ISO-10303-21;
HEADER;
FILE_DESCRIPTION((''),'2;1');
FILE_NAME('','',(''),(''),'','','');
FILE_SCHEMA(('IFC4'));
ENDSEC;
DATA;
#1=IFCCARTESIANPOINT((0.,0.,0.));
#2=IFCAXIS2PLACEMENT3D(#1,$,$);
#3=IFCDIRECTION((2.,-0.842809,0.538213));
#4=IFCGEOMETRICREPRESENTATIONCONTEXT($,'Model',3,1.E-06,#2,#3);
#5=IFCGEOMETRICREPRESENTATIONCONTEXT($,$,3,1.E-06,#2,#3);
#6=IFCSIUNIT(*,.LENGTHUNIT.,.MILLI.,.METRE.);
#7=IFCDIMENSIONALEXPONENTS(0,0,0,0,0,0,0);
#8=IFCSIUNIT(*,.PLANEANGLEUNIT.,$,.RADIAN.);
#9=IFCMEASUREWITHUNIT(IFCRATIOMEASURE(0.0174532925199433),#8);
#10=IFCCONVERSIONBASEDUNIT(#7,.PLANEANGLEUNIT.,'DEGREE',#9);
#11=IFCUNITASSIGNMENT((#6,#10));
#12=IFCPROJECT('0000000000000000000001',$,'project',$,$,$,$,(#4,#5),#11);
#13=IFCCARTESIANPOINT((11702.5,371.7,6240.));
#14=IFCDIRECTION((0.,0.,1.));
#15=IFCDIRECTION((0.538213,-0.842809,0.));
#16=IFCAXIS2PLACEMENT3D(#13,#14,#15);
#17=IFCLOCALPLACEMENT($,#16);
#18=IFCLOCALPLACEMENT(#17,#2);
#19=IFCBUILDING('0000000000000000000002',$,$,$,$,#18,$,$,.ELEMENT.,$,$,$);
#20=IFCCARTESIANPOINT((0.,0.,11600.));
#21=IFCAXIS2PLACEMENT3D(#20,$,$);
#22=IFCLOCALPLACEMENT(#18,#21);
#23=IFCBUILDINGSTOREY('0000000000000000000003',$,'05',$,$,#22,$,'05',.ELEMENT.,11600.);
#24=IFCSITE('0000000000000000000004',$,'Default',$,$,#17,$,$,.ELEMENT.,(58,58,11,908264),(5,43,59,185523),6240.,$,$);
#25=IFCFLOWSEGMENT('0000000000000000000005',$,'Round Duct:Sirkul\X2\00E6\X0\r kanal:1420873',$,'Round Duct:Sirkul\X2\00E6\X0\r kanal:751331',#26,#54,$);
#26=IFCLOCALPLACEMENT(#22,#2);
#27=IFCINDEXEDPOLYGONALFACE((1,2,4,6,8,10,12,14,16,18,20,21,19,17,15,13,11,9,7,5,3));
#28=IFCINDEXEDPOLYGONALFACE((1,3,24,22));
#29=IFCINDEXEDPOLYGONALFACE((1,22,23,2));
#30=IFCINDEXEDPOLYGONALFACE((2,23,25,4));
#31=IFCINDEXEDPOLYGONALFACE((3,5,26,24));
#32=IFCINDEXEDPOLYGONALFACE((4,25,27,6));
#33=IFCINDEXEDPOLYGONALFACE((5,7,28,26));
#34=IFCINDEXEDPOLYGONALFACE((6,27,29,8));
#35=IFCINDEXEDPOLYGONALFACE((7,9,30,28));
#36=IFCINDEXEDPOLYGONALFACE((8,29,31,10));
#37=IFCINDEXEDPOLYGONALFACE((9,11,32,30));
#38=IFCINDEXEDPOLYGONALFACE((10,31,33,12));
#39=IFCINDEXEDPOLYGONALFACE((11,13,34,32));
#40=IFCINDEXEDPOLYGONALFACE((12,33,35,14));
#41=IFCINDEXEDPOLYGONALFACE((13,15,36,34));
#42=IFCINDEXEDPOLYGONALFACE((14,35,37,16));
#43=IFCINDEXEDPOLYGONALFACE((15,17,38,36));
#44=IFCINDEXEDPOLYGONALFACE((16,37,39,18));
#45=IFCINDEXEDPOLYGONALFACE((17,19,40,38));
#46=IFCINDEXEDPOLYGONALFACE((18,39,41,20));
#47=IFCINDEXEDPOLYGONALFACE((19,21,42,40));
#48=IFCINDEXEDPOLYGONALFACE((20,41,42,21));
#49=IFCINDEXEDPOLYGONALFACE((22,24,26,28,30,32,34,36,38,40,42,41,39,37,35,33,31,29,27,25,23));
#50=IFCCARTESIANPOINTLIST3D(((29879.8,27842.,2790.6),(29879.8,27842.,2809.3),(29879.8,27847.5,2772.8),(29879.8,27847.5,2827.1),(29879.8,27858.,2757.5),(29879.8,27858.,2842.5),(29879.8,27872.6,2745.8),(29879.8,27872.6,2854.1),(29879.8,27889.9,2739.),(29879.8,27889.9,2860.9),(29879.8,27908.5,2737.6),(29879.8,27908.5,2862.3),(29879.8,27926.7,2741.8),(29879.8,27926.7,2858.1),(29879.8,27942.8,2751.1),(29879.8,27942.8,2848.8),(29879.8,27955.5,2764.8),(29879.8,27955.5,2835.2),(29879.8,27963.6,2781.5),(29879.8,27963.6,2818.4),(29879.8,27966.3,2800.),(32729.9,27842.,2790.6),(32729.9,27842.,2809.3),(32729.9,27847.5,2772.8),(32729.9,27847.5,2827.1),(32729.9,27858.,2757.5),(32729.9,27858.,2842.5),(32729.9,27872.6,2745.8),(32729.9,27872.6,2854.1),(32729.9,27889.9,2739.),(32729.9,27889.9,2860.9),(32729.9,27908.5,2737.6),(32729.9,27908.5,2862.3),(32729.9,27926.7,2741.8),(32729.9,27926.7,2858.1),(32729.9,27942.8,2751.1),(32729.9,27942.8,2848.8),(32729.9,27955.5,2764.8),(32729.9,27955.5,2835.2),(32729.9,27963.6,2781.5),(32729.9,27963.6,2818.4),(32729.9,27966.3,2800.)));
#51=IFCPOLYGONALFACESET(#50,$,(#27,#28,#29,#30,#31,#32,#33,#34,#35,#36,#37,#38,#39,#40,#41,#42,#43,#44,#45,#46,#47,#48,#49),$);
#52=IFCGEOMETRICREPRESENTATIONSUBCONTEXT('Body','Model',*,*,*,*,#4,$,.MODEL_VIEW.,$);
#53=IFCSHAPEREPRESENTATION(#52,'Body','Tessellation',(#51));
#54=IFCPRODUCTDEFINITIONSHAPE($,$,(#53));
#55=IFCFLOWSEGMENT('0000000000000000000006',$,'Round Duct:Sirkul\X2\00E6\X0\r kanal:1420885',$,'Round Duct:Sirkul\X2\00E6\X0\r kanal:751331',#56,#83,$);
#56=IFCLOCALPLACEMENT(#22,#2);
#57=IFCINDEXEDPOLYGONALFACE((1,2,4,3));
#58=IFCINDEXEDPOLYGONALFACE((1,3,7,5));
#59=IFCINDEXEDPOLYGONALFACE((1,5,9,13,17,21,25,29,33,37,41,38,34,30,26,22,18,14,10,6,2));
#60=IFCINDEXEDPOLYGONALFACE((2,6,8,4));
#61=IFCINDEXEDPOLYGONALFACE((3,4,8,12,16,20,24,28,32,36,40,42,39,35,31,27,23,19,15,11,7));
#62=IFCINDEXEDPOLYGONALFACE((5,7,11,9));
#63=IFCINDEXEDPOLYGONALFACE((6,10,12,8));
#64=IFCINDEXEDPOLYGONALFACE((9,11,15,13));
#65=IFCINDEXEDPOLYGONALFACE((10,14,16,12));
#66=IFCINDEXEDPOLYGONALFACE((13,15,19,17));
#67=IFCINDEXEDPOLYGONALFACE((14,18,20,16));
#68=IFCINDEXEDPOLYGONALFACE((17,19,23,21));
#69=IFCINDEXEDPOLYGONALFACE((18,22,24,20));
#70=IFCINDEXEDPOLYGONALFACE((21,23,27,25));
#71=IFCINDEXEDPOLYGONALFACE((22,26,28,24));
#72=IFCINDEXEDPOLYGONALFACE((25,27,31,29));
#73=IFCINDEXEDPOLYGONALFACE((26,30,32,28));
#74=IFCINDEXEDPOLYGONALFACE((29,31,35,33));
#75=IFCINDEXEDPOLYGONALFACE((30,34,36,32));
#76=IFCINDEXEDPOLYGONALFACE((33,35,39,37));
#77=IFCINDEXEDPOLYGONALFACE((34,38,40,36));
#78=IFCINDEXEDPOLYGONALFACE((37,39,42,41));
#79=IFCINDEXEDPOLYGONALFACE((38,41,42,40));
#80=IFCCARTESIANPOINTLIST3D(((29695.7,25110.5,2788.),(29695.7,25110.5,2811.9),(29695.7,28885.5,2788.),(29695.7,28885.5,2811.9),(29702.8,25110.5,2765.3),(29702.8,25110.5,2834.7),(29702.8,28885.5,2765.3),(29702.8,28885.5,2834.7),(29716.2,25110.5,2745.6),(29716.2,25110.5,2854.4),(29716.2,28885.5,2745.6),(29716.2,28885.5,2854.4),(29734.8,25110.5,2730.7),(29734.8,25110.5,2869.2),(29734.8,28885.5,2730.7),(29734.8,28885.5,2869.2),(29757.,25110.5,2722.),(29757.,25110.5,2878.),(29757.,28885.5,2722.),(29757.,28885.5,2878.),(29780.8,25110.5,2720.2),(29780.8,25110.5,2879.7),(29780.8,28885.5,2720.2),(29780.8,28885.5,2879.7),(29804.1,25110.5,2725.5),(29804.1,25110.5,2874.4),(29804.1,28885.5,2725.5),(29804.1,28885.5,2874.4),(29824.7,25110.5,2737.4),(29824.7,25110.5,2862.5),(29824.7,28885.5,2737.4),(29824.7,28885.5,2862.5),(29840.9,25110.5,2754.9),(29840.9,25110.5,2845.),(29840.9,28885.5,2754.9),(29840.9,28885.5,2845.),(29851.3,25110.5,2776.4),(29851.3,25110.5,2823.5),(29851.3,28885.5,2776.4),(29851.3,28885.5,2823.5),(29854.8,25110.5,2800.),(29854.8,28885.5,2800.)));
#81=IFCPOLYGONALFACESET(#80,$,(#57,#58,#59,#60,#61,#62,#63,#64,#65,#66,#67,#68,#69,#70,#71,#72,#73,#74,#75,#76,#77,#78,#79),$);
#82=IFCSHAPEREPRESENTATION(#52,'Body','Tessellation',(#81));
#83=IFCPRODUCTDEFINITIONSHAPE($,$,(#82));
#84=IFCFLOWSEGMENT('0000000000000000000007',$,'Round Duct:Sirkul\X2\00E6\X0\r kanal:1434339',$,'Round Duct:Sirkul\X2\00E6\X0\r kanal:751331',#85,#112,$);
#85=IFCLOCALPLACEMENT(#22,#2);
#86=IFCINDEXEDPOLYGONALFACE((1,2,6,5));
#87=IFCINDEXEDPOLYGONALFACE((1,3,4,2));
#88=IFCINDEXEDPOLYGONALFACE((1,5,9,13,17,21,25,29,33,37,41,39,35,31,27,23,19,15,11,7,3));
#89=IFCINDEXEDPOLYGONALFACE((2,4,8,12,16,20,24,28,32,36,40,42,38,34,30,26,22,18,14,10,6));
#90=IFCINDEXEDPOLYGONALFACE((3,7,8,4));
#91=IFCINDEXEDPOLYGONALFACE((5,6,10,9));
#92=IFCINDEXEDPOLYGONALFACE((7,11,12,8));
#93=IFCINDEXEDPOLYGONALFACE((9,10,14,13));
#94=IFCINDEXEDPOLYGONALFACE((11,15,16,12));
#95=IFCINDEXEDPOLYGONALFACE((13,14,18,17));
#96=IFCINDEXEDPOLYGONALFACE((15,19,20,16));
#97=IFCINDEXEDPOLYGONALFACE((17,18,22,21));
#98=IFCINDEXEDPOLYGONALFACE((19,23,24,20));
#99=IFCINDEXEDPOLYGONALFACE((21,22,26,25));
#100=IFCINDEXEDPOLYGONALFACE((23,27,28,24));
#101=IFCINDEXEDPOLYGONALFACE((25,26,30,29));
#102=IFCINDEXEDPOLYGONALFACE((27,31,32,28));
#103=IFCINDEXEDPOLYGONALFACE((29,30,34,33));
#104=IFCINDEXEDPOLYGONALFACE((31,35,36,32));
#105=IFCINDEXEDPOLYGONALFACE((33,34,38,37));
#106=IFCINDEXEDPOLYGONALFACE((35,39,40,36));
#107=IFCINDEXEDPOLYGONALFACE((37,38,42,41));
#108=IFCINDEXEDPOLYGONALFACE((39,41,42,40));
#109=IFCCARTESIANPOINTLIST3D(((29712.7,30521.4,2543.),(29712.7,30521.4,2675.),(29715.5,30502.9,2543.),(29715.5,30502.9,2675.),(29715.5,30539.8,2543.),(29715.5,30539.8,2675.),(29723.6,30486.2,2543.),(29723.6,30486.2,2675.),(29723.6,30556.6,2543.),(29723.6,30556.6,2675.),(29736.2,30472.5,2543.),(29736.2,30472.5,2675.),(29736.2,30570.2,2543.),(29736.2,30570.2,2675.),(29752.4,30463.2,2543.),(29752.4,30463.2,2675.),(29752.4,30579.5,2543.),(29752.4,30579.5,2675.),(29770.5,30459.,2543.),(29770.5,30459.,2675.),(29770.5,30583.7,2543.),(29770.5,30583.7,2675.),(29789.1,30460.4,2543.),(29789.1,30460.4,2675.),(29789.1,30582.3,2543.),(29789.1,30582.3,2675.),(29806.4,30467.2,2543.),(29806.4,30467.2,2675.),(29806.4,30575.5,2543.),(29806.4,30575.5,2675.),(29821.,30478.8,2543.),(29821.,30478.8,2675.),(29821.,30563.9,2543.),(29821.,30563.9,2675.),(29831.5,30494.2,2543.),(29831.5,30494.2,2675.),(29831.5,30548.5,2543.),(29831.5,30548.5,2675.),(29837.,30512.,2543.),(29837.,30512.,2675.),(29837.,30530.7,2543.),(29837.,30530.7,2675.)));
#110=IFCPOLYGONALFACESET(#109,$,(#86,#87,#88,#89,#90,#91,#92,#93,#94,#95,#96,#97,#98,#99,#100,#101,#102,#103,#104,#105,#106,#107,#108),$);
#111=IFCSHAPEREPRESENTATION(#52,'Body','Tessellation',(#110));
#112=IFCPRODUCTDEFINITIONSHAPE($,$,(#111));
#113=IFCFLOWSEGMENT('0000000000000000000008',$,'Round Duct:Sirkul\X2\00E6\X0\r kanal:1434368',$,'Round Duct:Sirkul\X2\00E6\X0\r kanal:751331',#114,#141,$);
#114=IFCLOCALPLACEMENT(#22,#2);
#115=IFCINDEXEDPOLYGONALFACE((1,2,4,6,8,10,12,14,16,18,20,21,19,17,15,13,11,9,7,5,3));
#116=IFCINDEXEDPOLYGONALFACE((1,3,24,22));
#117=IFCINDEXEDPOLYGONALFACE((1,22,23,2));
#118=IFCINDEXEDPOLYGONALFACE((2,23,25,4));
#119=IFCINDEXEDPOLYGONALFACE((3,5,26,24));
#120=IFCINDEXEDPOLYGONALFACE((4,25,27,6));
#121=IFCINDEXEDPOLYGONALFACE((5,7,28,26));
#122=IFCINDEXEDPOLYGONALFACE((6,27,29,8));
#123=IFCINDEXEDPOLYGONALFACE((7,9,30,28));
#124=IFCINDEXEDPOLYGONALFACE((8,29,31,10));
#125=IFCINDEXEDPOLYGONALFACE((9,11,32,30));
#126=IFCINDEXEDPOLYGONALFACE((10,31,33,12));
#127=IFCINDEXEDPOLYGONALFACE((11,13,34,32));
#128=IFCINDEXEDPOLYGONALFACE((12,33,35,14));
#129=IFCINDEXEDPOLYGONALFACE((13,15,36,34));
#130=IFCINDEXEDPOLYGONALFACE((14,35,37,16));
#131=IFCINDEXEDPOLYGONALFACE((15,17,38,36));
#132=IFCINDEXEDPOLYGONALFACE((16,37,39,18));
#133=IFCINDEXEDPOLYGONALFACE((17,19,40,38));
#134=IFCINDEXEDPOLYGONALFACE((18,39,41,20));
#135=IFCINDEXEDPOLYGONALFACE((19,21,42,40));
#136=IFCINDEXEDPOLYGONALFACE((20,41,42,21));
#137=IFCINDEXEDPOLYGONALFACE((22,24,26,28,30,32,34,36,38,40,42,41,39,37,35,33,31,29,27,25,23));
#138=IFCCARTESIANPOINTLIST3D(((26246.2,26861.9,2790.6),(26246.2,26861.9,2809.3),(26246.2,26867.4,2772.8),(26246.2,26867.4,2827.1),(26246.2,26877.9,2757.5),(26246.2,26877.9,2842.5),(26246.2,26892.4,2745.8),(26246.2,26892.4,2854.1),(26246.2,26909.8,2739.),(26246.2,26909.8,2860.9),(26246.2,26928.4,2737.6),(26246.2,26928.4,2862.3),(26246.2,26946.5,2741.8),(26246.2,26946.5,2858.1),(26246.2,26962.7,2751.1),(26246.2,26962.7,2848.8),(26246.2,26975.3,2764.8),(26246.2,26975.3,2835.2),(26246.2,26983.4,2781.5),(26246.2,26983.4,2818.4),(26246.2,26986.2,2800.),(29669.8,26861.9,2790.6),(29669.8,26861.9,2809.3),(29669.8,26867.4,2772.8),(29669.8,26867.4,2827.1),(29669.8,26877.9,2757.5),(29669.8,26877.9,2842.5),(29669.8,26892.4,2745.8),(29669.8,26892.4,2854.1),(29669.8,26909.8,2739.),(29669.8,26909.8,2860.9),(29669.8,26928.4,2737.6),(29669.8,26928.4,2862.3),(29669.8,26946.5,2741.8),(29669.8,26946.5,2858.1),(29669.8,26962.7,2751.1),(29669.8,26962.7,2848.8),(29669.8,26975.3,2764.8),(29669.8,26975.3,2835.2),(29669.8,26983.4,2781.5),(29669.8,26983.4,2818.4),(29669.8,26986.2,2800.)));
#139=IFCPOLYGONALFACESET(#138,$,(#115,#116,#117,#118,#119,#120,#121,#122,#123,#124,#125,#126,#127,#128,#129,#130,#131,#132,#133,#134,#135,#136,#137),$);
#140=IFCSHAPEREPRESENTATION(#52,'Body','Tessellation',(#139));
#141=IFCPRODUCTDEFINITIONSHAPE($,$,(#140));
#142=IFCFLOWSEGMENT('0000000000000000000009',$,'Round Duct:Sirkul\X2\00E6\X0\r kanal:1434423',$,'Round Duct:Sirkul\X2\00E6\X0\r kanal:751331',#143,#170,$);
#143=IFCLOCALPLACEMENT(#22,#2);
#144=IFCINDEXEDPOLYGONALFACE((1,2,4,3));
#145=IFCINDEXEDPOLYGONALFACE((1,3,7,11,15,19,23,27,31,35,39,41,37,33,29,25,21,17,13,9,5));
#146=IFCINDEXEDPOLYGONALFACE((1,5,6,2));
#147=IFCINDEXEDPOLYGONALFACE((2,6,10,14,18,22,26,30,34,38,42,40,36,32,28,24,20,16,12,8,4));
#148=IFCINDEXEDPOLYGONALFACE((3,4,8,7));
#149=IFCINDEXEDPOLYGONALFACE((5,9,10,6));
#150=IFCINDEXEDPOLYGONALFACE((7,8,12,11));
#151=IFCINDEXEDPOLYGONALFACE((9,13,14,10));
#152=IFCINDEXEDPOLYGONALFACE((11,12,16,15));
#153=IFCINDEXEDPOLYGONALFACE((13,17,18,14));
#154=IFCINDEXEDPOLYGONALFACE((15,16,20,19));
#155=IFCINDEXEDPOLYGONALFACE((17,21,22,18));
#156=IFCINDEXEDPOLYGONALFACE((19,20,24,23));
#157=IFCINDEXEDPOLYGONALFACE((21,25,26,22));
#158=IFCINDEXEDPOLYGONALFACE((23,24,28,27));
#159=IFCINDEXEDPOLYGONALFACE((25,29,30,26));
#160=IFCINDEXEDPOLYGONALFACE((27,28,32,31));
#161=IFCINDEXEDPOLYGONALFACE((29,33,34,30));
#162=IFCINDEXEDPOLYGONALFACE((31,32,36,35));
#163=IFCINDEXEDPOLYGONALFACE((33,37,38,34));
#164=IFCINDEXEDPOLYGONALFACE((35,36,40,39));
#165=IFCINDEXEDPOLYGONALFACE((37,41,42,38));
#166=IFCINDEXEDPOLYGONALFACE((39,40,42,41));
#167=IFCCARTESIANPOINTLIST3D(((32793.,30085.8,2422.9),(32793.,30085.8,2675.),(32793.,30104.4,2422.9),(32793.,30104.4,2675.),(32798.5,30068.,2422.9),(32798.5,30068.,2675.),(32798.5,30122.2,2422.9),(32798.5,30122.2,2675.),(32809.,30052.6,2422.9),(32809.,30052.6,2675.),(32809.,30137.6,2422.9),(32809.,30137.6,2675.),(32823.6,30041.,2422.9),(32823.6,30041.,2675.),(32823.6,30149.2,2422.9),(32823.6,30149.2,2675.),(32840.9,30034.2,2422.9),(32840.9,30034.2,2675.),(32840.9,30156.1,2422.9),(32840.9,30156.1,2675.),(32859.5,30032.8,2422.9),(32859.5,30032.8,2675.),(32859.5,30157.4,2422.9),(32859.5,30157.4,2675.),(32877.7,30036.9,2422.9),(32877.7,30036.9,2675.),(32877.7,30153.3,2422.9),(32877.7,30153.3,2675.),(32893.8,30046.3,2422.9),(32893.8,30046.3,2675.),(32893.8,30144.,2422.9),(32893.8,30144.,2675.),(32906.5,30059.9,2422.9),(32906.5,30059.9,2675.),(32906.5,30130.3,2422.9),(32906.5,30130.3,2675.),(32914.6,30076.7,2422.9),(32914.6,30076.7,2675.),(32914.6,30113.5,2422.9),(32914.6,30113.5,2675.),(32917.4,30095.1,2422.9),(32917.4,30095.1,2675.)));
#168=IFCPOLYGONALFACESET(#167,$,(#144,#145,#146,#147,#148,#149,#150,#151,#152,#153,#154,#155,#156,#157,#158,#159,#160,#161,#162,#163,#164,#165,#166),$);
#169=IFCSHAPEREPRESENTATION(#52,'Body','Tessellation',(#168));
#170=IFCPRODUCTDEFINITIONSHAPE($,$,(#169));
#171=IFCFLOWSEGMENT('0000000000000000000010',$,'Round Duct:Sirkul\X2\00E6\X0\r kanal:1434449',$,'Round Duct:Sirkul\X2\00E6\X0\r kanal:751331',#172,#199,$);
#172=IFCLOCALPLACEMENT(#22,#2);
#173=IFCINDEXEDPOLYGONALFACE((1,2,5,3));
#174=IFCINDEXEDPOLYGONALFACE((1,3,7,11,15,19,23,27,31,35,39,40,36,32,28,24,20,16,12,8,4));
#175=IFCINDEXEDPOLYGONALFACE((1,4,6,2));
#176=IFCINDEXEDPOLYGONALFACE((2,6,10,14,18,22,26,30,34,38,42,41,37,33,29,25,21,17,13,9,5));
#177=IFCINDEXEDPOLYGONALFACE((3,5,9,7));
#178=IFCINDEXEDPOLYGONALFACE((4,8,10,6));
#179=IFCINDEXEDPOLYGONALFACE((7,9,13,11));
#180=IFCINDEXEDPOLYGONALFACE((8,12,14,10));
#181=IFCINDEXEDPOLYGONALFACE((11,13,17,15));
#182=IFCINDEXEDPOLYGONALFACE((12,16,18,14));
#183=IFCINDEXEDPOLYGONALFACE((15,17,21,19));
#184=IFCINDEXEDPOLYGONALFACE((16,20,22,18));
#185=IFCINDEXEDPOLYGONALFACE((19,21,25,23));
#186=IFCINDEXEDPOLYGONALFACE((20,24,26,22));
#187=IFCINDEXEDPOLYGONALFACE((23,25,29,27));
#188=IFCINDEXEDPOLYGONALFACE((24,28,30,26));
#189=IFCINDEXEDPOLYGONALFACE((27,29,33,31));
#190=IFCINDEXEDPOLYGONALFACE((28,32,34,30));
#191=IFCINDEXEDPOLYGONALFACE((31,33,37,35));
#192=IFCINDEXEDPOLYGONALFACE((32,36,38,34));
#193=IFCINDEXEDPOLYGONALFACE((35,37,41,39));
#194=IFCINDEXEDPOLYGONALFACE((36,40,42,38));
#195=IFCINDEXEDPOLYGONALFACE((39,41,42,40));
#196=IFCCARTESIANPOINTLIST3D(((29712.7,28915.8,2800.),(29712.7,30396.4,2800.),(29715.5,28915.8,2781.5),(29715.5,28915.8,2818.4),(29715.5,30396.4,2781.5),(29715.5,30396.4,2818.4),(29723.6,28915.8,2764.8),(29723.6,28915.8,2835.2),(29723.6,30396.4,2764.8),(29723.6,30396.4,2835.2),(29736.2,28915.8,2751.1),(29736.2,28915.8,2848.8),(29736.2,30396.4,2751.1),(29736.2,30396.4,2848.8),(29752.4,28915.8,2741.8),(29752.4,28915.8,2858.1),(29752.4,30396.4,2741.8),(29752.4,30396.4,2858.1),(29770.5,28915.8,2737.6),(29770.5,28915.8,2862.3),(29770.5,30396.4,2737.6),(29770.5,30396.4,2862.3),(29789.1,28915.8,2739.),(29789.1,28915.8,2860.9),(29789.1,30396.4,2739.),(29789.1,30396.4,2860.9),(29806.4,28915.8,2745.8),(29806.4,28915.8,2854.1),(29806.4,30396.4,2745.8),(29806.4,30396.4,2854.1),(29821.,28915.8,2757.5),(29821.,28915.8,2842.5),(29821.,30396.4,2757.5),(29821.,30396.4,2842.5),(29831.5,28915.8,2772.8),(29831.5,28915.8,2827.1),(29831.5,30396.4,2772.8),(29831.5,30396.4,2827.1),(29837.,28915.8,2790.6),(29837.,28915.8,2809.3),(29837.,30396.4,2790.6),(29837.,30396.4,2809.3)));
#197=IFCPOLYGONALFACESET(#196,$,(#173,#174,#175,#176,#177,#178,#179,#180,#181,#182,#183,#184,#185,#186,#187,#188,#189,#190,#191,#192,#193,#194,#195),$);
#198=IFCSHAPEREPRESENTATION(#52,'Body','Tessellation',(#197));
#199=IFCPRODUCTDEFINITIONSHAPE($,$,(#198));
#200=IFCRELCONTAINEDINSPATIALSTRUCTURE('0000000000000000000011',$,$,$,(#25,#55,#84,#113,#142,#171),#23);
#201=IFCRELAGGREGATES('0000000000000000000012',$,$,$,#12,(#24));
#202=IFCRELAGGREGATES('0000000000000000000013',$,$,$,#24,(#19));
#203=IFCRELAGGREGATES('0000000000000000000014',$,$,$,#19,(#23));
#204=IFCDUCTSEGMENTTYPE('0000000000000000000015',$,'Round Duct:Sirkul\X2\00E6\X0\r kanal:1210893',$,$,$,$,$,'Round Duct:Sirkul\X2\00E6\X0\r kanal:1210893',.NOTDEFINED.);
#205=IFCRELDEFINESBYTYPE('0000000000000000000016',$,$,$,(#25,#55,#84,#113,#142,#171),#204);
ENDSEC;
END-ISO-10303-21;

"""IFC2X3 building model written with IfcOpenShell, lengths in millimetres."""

from ifc_helpers import new_model, entity, si_unit, converted_unit, direction, frame, frame_2d, origin, origin_2d_with_axis, place, context, subcontext, project, spatial, circle, extrude, type_object, element, save


model = new_model("IFC2X3")

# Units and contexts
model_context = context("Model", 3, precision=1e-06, world=origin(), true_north=direction((2.0, -0.842809, 0.538213)))
context_of_model = context(None, 3, precision=1e-06, world=origin(), true_north=direction((2.0, -0.842809, 0.538213)))
body_context = subcontext(model_context, "Body", "Model", "MODEL_VIEW")
ifc_project = project(units=[si_unit("LENGTHUNIT", "METRE", prefix="MILLI"), converted_unit("PLANEANGLEUNIT", "DEGREE", entity("IfcRatioMeasure", 0.0174532925199433), si_unit("PLANEANGLEUNIT", "RADIAN"), dimensions=[0, 0, 0, 0, 0, 0, 0])], contexts=[model_context, context_of_model])

# Site, building, storey
site_placement = place(None, frame((11702.5, 371.7, 6240.0), z_axis=(0.0, 0.0, 1.0), x_axis=(0.538213, -0.842809, 0.0)))
site = spatial("IfcSite", under=ifc_project, at=site_placement, Name="Default", CompositionType="ELEMENT", RefLatitude=(58, 58, 11, 908264), RefLongitude=(5, 43, 59, 185523), RefElevation=6240.0)
building_placement = place(site_placement, origin())
building = spatial("IfcBuilding", under=site, at=building_placement, CompositionType="ELEMENT")
storey_placement = place(building_placement, frame((0.0, 0.0, 11600.0)))
storey = spatial("IfcBuildingStorey", under=building, at=storey_placement, Name="05", LongName="05", CompositionType="ELEMENT", Elevation=11600.0)

# Flow segments
duct_segment_type = type_object("IfcDuctSegmentType", Name="Round Duct:Sirkulær kanal:1210893", ElementType="Round Duct:Sirkulær kanal:1210893", PredefinedType="NOTDEFINED")
flow_segment_1_placement = place(storey_placement, origin())
element("IfcFlowSegment", 1, at=flow_segment_1_placement, inside=storey, type_object=duct_segment_type, Name="Round Duct:Sirkulær kanal:1420873", ObjectType="Round Duct:Sirkulær kanal:751331", context=body_context, shape_type="SweptSolid", body=[
    extrude(circle(Radius=62.5, at=frame_2d((0.0, 0.0), x_axis=(1.0, 0.0))), frame((29879.8, 27903.8, 2800.0), z_axis=(1.0, 0.0, 0.0), x_axis=(0.0, 1.0, 0.0)), (0.0, 0.0, 1.0), 2850.0),
])
flow_segment_2_placement = place(storey_placement, origin())
element("IfcFlowSegment", 2, at=flow_segment_2_placement, inside=storey, type_object=duct_segment_type, Name="Round Duct:Sirkulær kanal:1420885", ObjectType="Round Duct:Sirkulær kanal:751331", context=body_context, shape_type="SweptSolid", body=[
    extrude(circle(Radius=80.0, at=origin_2d_with_axis()), frame((29774.8, 25110.5, 2800.0), z_axis=(0.0, 1.0, 0.0), x_axis=(1.0, 0.0, 0.0)), (0.0, 0.0, 1.0), 3775.0),
])
flow_segment_3_placement = place(storey_placement, origin())
element("IfcFlowSegment", 3, at=flow_segment_3_placement, inside=storey, type_object=duct_segment_type, Name="Round Duct:Sirkulær kanal:1434339", ObjectType="Round Duct:Sirkulær kanal:751331", context=body_context, shape_type="SweptSolid", body=[
    extrude(circle(Radius=62.5, at=origin_2d_with_axis()), frame((29775.2, 30521.4, 2543.0), z_axis=(0.0, 0.0, 1.0), x_axis=(-1.0, 0.0, 0.0)), (0.0, 0.0, 1.0), 132.0),
])
flow_segment_4_placement = place(storey_placement, origin())
element("IfcFlowSegment", 4, at=flow_segment_4_placement, inside=storey, type_object=duct_segment_type, Name="Round Duct:Sirkulær kanal:1434368", ObjectType="Round Duct:Sirkulær kanal:751331", context=body_context, shape_type="SweptSolid", body=[
    extrude(circle(Radius=62.5, at=frame_2d((0.0, 0.0), x_axis=(1.0, 0.0))), frame((26246.2, 26923.7, 2800.0), z_axis=(1.0, 0.0, 0.0), x_axis=(0.0, 1.0, 0.0)), (0.0, 0.0, 1.0), 3423.6),
])
flow_segment_5_placement = place(storey_placement, origin())
element("IfcFlowSegment", 5, at=flow_segment_5_placement, inside=storey, type_object=duct_segment_type, Name="Round Duct:Sirkulær kanal:1434423", ObjectType="Round Duct:Sirkulær kanal:751331", context=body_context, shape_type="SweptSolid", body=[
    extrude(circle(Radius=62.5, at=origin_2d_with_axis()), frame((32854.9, 30095.1, 2422.9)), (0.0, 0.0, 1.0), 252.0),
])
flow_segment_6_placement = place(storey_placement, origin())
element("IfcFlowSegment", 6, at=flow_segment_6_placement, inside=storey, type_object=duct_segment_type, Name="Round Duct:Sirkulær kanal:1434449", ObjectType="Round Duct:Sirkulær kanal:751331", context=body_context, shape_type="SweptSolid", body=[
    extrude(circle(Radius=62.5, at=origin_2d_with_axis()), frame((29775.2, 28915.8, 2800.0), z_axis=(0.0, 1.0, 0.0), x_axis=(-1.0, 0.0, 0.0)), (0.0, 0.0, 1.0), 1480.6),
])

save(model, "model.ifc")
